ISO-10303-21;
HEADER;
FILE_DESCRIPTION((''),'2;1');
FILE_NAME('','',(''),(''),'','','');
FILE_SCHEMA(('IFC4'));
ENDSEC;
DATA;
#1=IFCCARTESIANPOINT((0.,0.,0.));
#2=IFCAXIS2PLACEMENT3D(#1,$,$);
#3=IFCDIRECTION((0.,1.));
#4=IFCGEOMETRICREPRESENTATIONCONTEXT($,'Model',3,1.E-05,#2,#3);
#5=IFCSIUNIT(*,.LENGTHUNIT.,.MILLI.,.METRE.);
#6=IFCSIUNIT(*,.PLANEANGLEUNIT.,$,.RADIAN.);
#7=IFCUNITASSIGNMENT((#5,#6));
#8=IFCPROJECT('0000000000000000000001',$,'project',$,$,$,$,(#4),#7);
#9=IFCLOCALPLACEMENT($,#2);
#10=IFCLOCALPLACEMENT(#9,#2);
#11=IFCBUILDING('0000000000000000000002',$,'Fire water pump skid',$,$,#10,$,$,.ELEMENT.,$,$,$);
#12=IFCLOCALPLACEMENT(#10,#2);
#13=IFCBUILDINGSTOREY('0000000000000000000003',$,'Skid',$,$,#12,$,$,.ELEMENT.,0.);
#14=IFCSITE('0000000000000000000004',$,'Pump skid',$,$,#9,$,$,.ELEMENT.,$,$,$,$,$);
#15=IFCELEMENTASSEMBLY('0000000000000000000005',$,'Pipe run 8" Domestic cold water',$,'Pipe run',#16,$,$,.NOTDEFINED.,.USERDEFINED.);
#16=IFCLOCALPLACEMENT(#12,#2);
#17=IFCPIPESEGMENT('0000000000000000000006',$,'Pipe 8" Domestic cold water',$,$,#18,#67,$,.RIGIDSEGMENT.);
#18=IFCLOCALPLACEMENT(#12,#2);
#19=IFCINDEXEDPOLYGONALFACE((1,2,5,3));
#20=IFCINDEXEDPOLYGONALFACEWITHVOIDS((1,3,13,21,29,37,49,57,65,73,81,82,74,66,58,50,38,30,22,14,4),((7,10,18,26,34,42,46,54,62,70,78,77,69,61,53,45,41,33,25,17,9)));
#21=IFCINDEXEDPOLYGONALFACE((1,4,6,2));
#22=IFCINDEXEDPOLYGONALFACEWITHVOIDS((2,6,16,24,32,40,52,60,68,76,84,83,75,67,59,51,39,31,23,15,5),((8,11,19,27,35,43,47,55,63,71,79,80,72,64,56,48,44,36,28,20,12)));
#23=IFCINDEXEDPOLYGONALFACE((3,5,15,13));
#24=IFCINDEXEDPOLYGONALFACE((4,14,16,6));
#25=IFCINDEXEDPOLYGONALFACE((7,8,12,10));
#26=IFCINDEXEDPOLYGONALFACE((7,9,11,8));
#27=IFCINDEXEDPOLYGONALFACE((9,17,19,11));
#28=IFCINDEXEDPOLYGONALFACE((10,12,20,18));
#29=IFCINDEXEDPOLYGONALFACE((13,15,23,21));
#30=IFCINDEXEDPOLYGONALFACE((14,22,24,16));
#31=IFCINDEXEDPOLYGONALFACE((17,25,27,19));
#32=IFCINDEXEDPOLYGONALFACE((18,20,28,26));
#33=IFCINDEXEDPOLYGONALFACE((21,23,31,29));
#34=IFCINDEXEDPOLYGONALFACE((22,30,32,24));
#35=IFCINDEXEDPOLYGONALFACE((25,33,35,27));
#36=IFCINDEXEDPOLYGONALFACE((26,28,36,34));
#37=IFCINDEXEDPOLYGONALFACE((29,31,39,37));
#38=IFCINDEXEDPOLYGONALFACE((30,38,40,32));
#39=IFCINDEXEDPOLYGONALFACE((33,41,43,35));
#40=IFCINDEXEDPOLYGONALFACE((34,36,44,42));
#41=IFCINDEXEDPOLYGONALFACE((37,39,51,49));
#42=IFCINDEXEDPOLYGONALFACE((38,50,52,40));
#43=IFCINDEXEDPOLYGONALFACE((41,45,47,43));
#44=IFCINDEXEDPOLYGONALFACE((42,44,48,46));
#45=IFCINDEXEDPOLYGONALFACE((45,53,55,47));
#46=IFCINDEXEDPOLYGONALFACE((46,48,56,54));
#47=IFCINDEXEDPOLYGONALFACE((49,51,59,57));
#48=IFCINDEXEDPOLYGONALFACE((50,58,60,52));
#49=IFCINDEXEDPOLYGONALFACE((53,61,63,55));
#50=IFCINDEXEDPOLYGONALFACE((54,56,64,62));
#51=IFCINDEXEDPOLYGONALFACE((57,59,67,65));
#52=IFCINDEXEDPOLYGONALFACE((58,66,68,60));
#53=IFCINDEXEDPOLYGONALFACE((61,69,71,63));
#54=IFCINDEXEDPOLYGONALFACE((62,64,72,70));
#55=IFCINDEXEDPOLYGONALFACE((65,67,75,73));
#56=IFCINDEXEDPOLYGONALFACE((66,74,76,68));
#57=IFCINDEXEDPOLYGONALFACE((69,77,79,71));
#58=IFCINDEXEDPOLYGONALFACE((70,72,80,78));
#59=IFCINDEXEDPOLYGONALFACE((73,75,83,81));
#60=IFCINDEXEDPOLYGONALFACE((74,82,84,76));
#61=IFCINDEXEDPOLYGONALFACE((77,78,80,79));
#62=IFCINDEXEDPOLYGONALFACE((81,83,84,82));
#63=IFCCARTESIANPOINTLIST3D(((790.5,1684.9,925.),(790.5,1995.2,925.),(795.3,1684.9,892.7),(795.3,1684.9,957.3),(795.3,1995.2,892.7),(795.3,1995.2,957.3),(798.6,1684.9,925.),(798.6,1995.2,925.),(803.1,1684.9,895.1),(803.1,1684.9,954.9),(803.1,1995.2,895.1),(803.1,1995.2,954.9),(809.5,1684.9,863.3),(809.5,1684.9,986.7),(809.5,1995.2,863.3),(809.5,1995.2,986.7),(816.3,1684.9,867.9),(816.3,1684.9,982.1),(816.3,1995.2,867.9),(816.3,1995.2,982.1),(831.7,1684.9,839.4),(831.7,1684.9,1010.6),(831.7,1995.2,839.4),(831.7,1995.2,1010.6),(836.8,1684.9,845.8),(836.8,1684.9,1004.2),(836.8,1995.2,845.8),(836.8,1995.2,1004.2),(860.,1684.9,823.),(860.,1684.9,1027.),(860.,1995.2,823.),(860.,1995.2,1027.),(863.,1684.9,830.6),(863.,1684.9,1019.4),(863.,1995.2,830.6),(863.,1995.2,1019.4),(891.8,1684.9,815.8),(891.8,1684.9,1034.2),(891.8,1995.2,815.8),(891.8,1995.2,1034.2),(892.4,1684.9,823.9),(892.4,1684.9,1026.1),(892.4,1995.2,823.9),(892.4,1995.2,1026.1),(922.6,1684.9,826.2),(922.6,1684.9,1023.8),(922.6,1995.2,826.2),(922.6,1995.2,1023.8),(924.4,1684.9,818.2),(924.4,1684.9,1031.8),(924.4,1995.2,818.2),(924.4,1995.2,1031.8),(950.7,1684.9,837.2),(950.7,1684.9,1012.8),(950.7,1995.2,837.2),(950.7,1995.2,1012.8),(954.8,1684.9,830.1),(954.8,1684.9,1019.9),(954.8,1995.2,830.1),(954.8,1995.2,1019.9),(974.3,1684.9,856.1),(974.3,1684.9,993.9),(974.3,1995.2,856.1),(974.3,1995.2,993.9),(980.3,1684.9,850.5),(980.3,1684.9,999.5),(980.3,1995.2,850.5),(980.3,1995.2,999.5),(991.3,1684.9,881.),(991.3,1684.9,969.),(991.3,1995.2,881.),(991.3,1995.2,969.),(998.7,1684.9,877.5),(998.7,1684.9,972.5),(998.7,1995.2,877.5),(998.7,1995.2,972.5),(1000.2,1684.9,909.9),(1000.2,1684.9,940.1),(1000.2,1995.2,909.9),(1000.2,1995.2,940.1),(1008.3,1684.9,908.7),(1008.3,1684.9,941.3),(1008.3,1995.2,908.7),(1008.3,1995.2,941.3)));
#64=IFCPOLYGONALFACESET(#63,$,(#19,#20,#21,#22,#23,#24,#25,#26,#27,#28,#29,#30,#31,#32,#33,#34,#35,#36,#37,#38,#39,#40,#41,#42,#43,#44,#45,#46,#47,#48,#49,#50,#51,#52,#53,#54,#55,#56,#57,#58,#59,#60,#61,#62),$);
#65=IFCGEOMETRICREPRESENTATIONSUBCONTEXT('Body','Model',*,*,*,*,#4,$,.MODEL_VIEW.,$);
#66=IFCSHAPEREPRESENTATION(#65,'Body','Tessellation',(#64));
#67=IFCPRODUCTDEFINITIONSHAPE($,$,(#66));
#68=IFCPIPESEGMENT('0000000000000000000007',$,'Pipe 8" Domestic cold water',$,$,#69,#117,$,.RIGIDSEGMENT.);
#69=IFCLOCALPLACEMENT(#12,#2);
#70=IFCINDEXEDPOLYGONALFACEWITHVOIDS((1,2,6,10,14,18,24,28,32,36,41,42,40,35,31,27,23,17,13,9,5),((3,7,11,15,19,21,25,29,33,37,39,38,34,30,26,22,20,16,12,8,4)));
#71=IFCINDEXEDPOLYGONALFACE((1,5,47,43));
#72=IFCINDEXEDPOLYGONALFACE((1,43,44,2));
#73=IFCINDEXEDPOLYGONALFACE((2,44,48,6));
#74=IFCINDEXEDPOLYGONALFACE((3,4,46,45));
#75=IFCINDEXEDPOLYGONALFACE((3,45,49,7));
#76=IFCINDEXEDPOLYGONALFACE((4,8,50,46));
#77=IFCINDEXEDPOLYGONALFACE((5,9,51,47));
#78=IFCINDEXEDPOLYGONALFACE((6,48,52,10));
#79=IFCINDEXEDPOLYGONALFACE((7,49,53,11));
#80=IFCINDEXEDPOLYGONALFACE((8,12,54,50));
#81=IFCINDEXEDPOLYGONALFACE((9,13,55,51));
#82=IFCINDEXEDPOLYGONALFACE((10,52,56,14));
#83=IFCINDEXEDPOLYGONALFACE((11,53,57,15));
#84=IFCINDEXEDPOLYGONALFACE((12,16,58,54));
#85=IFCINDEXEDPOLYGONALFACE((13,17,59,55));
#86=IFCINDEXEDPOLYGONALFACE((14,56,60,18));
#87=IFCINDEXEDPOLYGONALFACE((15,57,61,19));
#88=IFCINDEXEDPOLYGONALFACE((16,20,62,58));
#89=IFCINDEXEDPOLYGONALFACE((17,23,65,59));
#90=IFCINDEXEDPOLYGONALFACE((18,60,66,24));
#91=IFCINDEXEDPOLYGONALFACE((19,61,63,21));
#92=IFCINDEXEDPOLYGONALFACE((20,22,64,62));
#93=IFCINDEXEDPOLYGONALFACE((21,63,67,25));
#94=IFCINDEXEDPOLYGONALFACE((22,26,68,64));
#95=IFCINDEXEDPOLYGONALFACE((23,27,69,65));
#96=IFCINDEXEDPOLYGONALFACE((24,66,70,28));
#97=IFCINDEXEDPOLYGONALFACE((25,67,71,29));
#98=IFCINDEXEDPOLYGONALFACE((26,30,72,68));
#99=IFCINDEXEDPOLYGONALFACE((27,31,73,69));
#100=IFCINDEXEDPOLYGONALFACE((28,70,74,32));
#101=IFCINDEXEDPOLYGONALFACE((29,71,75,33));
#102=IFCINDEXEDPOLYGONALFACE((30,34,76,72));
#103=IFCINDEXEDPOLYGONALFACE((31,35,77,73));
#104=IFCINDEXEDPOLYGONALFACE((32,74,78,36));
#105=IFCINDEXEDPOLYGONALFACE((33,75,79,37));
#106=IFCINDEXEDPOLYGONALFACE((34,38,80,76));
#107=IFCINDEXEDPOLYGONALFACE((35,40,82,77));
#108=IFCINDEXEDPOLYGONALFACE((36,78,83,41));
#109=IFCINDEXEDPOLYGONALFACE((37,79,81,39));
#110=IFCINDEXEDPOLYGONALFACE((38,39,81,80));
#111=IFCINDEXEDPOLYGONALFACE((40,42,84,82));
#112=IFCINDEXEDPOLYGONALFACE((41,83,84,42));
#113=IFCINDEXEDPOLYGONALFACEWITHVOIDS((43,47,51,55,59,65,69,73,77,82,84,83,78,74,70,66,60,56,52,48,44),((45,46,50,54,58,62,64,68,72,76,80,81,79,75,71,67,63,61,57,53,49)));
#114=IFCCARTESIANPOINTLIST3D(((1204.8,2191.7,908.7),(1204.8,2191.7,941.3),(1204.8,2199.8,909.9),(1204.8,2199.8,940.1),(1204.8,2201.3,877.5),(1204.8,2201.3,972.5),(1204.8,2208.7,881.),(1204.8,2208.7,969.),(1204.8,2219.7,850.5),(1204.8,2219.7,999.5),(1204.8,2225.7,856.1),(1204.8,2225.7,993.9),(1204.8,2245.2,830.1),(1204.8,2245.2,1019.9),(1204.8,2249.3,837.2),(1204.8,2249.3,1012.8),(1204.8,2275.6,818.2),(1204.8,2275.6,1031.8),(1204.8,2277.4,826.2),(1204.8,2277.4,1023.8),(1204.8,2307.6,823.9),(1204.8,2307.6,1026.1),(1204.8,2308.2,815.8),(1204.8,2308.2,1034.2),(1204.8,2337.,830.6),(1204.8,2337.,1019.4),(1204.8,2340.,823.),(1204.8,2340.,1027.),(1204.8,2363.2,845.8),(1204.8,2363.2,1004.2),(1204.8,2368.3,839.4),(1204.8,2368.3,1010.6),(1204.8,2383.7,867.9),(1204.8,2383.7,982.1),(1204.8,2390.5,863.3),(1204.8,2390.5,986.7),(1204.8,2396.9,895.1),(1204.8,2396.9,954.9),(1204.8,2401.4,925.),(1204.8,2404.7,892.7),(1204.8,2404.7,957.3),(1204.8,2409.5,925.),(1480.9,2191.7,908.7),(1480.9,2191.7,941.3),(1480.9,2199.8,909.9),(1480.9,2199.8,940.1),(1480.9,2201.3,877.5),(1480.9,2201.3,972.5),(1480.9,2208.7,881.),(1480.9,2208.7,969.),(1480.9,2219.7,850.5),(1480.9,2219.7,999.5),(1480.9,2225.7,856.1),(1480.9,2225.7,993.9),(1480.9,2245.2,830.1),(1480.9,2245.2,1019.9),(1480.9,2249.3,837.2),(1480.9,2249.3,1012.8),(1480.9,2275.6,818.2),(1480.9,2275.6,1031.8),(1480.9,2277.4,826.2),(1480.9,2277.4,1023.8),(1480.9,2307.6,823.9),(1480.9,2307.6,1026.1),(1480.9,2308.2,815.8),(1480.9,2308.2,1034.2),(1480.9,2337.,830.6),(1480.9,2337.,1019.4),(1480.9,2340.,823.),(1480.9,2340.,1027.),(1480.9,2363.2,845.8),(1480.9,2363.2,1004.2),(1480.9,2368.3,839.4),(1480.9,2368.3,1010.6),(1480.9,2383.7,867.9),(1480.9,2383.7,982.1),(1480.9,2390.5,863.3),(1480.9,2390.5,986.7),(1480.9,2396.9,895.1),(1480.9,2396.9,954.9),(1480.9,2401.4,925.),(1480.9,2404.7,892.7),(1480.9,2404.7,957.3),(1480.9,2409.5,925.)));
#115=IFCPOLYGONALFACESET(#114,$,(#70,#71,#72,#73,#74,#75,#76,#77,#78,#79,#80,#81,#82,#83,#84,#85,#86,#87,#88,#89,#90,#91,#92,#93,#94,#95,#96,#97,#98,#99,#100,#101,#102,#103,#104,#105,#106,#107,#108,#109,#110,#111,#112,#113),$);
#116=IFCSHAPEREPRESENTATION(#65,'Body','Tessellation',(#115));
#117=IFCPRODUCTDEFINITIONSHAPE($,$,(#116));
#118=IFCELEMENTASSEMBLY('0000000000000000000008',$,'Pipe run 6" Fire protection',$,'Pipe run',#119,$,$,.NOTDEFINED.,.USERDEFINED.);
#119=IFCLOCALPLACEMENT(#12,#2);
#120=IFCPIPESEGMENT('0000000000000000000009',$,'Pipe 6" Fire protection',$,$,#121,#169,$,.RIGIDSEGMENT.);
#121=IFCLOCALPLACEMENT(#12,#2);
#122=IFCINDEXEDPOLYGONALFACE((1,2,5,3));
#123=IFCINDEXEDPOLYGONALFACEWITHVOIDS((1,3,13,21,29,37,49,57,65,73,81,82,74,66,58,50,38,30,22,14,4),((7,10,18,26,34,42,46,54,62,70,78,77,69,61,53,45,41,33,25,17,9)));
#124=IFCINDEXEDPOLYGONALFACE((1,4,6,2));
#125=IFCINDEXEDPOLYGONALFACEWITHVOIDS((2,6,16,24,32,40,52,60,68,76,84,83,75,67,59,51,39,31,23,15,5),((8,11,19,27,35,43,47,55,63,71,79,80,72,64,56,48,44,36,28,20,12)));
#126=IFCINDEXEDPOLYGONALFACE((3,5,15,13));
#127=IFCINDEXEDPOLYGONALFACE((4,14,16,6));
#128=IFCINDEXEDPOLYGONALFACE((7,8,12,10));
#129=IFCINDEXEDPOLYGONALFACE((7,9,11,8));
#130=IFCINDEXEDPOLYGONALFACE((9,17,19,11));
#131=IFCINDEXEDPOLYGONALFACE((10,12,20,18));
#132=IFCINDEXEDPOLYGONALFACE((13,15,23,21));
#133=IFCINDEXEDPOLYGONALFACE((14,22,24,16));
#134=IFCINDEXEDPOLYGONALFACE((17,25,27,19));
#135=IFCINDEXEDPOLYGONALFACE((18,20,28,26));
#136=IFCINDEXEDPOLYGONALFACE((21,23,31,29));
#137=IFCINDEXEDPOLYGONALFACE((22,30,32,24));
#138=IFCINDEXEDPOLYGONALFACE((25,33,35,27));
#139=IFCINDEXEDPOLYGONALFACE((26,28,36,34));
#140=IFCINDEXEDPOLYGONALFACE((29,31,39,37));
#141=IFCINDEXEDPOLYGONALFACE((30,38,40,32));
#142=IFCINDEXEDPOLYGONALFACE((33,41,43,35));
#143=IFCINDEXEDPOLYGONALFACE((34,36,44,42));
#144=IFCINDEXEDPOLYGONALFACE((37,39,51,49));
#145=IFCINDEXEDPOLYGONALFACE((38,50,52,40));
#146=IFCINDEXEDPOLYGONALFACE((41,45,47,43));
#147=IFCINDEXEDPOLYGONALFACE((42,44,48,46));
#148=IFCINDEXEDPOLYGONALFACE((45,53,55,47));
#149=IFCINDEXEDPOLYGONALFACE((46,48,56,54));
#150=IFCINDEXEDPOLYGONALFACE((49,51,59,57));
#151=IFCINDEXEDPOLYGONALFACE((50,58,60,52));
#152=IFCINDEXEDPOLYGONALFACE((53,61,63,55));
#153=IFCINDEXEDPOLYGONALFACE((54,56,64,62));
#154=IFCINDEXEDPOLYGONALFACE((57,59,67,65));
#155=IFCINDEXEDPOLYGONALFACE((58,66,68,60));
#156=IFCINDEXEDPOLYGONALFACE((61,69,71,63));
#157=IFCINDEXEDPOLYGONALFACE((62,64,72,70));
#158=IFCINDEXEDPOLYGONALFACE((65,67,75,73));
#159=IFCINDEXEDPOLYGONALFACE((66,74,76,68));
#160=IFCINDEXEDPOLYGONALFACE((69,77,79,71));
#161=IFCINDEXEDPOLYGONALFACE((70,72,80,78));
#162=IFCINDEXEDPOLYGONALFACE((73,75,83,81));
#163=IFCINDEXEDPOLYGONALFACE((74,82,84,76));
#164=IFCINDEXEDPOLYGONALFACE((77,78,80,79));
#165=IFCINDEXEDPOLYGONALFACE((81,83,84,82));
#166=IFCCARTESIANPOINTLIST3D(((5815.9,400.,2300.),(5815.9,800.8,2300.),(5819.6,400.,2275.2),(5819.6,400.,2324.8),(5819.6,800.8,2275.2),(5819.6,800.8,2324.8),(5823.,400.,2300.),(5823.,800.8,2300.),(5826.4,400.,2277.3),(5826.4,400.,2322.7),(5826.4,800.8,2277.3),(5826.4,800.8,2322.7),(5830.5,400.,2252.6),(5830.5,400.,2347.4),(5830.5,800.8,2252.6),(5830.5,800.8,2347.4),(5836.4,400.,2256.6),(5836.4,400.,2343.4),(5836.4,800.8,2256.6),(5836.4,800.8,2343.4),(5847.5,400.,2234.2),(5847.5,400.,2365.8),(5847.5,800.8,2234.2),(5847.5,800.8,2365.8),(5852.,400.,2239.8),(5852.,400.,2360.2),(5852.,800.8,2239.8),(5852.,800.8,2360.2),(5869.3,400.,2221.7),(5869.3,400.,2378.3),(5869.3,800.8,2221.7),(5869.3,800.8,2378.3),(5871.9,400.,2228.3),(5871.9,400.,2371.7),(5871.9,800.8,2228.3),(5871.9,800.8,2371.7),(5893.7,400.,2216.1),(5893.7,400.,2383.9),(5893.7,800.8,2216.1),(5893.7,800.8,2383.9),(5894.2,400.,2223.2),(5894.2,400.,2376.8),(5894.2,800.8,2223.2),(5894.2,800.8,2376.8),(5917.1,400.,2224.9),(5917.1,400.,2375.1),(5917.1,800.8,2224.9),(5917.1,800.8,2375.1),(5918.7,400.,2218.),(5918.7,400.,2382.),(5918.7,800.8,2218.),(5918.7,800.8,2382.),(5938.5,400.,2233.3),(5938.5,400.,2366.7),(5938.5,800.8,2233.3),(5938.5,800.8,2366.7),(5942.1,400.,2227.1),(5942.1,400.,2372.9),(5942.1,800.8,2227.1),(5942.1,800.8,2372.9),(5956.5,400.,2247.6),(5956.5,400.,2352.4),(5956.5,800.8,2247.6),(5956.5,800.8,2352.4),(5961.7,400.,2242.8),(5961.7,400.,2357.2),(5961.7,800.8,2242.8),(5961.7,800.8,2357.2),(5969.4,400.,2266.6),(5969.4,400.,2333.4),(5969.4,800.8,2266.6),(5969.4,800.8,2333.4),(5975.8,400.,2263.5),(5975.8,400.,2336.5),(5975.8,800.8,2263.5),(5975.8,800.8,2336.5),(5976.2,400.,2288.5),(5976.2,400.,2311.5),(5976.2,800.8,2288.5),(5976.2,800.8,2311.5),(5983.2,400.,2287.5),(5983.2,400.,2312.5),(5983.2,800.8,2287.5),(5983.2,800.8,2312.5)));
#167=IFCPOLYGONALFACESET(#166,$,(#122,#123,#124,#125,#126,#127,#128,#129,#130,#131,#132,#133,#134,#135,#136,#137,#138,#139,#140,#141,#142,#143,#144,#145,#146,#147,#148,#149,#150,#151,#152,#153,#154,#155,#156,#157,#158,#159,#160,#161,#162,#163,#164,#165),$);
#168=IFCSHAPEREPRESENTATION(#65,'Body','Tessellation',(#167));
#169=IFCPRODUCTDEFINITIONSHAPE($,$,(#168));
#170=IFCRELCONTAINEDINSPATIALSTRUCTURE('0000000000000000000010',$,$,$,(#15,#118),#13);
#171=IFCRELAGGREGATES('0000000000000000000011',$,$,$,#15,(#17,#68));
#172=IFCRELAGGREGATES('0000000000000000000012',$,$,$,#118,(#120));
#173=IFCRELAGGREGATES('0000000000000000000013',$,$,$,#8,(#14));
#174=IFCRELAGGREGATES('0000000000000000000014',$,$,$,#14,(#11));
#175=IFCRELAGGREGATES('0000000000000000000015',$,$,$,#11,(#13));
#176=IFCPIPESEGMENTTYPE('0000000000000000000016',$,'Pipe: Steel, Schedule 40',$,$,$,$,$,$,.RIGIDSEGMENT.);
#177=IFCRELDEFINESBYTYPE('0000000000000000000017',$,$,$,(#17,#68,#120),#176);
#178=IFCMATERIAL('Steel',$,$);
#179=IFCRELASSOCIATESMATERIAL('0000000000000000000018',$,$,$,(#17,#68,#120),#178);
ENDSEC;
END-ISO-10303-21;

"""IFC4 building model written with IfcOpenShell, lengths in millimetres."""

from ifc_helpers import new_model, si_unit, direction, frame, origin, origin_with_axes, origin_2d, place, context, subcontext, project, spatial, hollow_circle, extrude, material, type_object, element, aggregate, save


model = new_model("IFC4")

# Units and contexts
model_context = context("Model", 3, precision=1e-05, world=origin(), true_north=direction((0.0, 1.0)))
body_context = subcontext(model_context, "Body", "Model", "MODEL_VIEW")
ifc_project = project(units=[si_unit("LENGTHUNIT", "METRE", prefix="MILLI"), si_unit("PLANEANGLEUNIT", "RADIAN")], contexts=[model_context])

# Site, building, storey
site_placement = place(None, origin())
site = spatial("IfcSite", under=ifc_project, at=site_placement, Name="Pump skid", CompositionType="ELEMENT")
building_placement = place(site_placement, origin())
building = spatial("IfcBuilding", under=site, at=building_placement, Name="Fire water pump skid", CompositionType="ELEMENT")
storey_placement = place(building_placement, origin())
storey = spatial("IfcBuildingStorey", under=building, at=storey_placement, Name="Skid", CompositionType="ELEMENT", Elevation=0.0)

# Element assemblies, pipe segments
assembly_1_placement = place(storey_placement, origin_with_axes())
assembly_1 = element("IfcElementAssembly", 1, at=assembly_1_placement, inside=storey, Name="Pipe run 8\" Domestic cold water", ObjectType="Pipe run", AssemblyPlace="NOTDEFINED", PredefinedType="USERDEFINED")
ifc_material = material(Name="Steel")
pipe_segment_type = type_object("IfcPipeSegmentType", Name="Pipe: Steel, Schedule 40", PredefinedType="RIGIDSEGMENT")
pipe_segment_1_placement = place(storey_placement, origin_with_axes())
pipe_segment_1 = element("IfcPipeSegment", 2, at=pipe_segment_1_placement, type_object=pipe_segment_type, material=ifc_material, Name="Pipe 8\" Domestic cold water", PredefinedType="RIGIDSEGMENT", context=body_context, shape_type="SweptSolid", body=[
    extrude(hollow_circle(Radius=109.5, WallThickness=8.2, at=origin_2d()), frame((900.0, 1684.9, 925.0), z_axis=(0.0, 1.0, 0.0), x_axis=(-1.0, 0.0, 0.0)), (0.0, 0.0, 1.0), 310.3),
])
pipe_segment_2_placement = place(storey_placement, origin_with_axes())
pipe_segment_2 = element("IfcPipeSegment", 3, at=pipe_segment_2_placement, type_object=pipe_segment_type, material=ifc_material, Name="Pipe 8\" Domestic cold water", PredefinedType="RIGIDSEGMENT", context=body_context, shape_type="SweptSolid", body=[
    extrude(hollow_circle(Radius=109.5, WallThickness=8.2, at=origin_2d()), frame((1204.8, 2300.0, 925.0), z_axis=(1.0, 0.0, 0.0), x_axis=(0.0, 1.0, 0.0)), (0.0, 0.0, 1.0), 276.1),
])
assembly_2_placement = place(storey_placement, origin_with_axes())
assembly_2 = element("IfcElementAssembly", 4, at=assembly_2_placement, inside=storey, Name="Pipe run 6\" Fire protection", ObjectType="Pipe run", AssemblyPlace="NOTDEFINED", PredefinedType="USERDEFINED")
pipe_segment_3_placement = place(storey_placement, origin_with_axes())
pipe_segment_3 = element("IfcPipeSegment", 5, at=pipe_segment_3_placement, type_object=pipe_segment_type, material=ifc_material, Name="Pipe 6\" Fire protection", PredefinedType="RIGIDSEGMENT", context=body_context, shape_type="SweptSolid", body=[
    extrude(hollow_circle(Radius=84.1, WallThickness=7.1, at=origin_2d()), frame((5900.0, 400.0, 2300.0), z_axis=(0.0, 1.0, 0.0), x_axis=(-1.0, 0.0, 0.0)), (0.0, 0.0, 1.0), 400.8),
])

aggregate(assembly_1, [pipe_segment_1, pipe_segment_2])
aggregate(assembly_2, [pipe_segment_3])

save(model, "model.ifc")
